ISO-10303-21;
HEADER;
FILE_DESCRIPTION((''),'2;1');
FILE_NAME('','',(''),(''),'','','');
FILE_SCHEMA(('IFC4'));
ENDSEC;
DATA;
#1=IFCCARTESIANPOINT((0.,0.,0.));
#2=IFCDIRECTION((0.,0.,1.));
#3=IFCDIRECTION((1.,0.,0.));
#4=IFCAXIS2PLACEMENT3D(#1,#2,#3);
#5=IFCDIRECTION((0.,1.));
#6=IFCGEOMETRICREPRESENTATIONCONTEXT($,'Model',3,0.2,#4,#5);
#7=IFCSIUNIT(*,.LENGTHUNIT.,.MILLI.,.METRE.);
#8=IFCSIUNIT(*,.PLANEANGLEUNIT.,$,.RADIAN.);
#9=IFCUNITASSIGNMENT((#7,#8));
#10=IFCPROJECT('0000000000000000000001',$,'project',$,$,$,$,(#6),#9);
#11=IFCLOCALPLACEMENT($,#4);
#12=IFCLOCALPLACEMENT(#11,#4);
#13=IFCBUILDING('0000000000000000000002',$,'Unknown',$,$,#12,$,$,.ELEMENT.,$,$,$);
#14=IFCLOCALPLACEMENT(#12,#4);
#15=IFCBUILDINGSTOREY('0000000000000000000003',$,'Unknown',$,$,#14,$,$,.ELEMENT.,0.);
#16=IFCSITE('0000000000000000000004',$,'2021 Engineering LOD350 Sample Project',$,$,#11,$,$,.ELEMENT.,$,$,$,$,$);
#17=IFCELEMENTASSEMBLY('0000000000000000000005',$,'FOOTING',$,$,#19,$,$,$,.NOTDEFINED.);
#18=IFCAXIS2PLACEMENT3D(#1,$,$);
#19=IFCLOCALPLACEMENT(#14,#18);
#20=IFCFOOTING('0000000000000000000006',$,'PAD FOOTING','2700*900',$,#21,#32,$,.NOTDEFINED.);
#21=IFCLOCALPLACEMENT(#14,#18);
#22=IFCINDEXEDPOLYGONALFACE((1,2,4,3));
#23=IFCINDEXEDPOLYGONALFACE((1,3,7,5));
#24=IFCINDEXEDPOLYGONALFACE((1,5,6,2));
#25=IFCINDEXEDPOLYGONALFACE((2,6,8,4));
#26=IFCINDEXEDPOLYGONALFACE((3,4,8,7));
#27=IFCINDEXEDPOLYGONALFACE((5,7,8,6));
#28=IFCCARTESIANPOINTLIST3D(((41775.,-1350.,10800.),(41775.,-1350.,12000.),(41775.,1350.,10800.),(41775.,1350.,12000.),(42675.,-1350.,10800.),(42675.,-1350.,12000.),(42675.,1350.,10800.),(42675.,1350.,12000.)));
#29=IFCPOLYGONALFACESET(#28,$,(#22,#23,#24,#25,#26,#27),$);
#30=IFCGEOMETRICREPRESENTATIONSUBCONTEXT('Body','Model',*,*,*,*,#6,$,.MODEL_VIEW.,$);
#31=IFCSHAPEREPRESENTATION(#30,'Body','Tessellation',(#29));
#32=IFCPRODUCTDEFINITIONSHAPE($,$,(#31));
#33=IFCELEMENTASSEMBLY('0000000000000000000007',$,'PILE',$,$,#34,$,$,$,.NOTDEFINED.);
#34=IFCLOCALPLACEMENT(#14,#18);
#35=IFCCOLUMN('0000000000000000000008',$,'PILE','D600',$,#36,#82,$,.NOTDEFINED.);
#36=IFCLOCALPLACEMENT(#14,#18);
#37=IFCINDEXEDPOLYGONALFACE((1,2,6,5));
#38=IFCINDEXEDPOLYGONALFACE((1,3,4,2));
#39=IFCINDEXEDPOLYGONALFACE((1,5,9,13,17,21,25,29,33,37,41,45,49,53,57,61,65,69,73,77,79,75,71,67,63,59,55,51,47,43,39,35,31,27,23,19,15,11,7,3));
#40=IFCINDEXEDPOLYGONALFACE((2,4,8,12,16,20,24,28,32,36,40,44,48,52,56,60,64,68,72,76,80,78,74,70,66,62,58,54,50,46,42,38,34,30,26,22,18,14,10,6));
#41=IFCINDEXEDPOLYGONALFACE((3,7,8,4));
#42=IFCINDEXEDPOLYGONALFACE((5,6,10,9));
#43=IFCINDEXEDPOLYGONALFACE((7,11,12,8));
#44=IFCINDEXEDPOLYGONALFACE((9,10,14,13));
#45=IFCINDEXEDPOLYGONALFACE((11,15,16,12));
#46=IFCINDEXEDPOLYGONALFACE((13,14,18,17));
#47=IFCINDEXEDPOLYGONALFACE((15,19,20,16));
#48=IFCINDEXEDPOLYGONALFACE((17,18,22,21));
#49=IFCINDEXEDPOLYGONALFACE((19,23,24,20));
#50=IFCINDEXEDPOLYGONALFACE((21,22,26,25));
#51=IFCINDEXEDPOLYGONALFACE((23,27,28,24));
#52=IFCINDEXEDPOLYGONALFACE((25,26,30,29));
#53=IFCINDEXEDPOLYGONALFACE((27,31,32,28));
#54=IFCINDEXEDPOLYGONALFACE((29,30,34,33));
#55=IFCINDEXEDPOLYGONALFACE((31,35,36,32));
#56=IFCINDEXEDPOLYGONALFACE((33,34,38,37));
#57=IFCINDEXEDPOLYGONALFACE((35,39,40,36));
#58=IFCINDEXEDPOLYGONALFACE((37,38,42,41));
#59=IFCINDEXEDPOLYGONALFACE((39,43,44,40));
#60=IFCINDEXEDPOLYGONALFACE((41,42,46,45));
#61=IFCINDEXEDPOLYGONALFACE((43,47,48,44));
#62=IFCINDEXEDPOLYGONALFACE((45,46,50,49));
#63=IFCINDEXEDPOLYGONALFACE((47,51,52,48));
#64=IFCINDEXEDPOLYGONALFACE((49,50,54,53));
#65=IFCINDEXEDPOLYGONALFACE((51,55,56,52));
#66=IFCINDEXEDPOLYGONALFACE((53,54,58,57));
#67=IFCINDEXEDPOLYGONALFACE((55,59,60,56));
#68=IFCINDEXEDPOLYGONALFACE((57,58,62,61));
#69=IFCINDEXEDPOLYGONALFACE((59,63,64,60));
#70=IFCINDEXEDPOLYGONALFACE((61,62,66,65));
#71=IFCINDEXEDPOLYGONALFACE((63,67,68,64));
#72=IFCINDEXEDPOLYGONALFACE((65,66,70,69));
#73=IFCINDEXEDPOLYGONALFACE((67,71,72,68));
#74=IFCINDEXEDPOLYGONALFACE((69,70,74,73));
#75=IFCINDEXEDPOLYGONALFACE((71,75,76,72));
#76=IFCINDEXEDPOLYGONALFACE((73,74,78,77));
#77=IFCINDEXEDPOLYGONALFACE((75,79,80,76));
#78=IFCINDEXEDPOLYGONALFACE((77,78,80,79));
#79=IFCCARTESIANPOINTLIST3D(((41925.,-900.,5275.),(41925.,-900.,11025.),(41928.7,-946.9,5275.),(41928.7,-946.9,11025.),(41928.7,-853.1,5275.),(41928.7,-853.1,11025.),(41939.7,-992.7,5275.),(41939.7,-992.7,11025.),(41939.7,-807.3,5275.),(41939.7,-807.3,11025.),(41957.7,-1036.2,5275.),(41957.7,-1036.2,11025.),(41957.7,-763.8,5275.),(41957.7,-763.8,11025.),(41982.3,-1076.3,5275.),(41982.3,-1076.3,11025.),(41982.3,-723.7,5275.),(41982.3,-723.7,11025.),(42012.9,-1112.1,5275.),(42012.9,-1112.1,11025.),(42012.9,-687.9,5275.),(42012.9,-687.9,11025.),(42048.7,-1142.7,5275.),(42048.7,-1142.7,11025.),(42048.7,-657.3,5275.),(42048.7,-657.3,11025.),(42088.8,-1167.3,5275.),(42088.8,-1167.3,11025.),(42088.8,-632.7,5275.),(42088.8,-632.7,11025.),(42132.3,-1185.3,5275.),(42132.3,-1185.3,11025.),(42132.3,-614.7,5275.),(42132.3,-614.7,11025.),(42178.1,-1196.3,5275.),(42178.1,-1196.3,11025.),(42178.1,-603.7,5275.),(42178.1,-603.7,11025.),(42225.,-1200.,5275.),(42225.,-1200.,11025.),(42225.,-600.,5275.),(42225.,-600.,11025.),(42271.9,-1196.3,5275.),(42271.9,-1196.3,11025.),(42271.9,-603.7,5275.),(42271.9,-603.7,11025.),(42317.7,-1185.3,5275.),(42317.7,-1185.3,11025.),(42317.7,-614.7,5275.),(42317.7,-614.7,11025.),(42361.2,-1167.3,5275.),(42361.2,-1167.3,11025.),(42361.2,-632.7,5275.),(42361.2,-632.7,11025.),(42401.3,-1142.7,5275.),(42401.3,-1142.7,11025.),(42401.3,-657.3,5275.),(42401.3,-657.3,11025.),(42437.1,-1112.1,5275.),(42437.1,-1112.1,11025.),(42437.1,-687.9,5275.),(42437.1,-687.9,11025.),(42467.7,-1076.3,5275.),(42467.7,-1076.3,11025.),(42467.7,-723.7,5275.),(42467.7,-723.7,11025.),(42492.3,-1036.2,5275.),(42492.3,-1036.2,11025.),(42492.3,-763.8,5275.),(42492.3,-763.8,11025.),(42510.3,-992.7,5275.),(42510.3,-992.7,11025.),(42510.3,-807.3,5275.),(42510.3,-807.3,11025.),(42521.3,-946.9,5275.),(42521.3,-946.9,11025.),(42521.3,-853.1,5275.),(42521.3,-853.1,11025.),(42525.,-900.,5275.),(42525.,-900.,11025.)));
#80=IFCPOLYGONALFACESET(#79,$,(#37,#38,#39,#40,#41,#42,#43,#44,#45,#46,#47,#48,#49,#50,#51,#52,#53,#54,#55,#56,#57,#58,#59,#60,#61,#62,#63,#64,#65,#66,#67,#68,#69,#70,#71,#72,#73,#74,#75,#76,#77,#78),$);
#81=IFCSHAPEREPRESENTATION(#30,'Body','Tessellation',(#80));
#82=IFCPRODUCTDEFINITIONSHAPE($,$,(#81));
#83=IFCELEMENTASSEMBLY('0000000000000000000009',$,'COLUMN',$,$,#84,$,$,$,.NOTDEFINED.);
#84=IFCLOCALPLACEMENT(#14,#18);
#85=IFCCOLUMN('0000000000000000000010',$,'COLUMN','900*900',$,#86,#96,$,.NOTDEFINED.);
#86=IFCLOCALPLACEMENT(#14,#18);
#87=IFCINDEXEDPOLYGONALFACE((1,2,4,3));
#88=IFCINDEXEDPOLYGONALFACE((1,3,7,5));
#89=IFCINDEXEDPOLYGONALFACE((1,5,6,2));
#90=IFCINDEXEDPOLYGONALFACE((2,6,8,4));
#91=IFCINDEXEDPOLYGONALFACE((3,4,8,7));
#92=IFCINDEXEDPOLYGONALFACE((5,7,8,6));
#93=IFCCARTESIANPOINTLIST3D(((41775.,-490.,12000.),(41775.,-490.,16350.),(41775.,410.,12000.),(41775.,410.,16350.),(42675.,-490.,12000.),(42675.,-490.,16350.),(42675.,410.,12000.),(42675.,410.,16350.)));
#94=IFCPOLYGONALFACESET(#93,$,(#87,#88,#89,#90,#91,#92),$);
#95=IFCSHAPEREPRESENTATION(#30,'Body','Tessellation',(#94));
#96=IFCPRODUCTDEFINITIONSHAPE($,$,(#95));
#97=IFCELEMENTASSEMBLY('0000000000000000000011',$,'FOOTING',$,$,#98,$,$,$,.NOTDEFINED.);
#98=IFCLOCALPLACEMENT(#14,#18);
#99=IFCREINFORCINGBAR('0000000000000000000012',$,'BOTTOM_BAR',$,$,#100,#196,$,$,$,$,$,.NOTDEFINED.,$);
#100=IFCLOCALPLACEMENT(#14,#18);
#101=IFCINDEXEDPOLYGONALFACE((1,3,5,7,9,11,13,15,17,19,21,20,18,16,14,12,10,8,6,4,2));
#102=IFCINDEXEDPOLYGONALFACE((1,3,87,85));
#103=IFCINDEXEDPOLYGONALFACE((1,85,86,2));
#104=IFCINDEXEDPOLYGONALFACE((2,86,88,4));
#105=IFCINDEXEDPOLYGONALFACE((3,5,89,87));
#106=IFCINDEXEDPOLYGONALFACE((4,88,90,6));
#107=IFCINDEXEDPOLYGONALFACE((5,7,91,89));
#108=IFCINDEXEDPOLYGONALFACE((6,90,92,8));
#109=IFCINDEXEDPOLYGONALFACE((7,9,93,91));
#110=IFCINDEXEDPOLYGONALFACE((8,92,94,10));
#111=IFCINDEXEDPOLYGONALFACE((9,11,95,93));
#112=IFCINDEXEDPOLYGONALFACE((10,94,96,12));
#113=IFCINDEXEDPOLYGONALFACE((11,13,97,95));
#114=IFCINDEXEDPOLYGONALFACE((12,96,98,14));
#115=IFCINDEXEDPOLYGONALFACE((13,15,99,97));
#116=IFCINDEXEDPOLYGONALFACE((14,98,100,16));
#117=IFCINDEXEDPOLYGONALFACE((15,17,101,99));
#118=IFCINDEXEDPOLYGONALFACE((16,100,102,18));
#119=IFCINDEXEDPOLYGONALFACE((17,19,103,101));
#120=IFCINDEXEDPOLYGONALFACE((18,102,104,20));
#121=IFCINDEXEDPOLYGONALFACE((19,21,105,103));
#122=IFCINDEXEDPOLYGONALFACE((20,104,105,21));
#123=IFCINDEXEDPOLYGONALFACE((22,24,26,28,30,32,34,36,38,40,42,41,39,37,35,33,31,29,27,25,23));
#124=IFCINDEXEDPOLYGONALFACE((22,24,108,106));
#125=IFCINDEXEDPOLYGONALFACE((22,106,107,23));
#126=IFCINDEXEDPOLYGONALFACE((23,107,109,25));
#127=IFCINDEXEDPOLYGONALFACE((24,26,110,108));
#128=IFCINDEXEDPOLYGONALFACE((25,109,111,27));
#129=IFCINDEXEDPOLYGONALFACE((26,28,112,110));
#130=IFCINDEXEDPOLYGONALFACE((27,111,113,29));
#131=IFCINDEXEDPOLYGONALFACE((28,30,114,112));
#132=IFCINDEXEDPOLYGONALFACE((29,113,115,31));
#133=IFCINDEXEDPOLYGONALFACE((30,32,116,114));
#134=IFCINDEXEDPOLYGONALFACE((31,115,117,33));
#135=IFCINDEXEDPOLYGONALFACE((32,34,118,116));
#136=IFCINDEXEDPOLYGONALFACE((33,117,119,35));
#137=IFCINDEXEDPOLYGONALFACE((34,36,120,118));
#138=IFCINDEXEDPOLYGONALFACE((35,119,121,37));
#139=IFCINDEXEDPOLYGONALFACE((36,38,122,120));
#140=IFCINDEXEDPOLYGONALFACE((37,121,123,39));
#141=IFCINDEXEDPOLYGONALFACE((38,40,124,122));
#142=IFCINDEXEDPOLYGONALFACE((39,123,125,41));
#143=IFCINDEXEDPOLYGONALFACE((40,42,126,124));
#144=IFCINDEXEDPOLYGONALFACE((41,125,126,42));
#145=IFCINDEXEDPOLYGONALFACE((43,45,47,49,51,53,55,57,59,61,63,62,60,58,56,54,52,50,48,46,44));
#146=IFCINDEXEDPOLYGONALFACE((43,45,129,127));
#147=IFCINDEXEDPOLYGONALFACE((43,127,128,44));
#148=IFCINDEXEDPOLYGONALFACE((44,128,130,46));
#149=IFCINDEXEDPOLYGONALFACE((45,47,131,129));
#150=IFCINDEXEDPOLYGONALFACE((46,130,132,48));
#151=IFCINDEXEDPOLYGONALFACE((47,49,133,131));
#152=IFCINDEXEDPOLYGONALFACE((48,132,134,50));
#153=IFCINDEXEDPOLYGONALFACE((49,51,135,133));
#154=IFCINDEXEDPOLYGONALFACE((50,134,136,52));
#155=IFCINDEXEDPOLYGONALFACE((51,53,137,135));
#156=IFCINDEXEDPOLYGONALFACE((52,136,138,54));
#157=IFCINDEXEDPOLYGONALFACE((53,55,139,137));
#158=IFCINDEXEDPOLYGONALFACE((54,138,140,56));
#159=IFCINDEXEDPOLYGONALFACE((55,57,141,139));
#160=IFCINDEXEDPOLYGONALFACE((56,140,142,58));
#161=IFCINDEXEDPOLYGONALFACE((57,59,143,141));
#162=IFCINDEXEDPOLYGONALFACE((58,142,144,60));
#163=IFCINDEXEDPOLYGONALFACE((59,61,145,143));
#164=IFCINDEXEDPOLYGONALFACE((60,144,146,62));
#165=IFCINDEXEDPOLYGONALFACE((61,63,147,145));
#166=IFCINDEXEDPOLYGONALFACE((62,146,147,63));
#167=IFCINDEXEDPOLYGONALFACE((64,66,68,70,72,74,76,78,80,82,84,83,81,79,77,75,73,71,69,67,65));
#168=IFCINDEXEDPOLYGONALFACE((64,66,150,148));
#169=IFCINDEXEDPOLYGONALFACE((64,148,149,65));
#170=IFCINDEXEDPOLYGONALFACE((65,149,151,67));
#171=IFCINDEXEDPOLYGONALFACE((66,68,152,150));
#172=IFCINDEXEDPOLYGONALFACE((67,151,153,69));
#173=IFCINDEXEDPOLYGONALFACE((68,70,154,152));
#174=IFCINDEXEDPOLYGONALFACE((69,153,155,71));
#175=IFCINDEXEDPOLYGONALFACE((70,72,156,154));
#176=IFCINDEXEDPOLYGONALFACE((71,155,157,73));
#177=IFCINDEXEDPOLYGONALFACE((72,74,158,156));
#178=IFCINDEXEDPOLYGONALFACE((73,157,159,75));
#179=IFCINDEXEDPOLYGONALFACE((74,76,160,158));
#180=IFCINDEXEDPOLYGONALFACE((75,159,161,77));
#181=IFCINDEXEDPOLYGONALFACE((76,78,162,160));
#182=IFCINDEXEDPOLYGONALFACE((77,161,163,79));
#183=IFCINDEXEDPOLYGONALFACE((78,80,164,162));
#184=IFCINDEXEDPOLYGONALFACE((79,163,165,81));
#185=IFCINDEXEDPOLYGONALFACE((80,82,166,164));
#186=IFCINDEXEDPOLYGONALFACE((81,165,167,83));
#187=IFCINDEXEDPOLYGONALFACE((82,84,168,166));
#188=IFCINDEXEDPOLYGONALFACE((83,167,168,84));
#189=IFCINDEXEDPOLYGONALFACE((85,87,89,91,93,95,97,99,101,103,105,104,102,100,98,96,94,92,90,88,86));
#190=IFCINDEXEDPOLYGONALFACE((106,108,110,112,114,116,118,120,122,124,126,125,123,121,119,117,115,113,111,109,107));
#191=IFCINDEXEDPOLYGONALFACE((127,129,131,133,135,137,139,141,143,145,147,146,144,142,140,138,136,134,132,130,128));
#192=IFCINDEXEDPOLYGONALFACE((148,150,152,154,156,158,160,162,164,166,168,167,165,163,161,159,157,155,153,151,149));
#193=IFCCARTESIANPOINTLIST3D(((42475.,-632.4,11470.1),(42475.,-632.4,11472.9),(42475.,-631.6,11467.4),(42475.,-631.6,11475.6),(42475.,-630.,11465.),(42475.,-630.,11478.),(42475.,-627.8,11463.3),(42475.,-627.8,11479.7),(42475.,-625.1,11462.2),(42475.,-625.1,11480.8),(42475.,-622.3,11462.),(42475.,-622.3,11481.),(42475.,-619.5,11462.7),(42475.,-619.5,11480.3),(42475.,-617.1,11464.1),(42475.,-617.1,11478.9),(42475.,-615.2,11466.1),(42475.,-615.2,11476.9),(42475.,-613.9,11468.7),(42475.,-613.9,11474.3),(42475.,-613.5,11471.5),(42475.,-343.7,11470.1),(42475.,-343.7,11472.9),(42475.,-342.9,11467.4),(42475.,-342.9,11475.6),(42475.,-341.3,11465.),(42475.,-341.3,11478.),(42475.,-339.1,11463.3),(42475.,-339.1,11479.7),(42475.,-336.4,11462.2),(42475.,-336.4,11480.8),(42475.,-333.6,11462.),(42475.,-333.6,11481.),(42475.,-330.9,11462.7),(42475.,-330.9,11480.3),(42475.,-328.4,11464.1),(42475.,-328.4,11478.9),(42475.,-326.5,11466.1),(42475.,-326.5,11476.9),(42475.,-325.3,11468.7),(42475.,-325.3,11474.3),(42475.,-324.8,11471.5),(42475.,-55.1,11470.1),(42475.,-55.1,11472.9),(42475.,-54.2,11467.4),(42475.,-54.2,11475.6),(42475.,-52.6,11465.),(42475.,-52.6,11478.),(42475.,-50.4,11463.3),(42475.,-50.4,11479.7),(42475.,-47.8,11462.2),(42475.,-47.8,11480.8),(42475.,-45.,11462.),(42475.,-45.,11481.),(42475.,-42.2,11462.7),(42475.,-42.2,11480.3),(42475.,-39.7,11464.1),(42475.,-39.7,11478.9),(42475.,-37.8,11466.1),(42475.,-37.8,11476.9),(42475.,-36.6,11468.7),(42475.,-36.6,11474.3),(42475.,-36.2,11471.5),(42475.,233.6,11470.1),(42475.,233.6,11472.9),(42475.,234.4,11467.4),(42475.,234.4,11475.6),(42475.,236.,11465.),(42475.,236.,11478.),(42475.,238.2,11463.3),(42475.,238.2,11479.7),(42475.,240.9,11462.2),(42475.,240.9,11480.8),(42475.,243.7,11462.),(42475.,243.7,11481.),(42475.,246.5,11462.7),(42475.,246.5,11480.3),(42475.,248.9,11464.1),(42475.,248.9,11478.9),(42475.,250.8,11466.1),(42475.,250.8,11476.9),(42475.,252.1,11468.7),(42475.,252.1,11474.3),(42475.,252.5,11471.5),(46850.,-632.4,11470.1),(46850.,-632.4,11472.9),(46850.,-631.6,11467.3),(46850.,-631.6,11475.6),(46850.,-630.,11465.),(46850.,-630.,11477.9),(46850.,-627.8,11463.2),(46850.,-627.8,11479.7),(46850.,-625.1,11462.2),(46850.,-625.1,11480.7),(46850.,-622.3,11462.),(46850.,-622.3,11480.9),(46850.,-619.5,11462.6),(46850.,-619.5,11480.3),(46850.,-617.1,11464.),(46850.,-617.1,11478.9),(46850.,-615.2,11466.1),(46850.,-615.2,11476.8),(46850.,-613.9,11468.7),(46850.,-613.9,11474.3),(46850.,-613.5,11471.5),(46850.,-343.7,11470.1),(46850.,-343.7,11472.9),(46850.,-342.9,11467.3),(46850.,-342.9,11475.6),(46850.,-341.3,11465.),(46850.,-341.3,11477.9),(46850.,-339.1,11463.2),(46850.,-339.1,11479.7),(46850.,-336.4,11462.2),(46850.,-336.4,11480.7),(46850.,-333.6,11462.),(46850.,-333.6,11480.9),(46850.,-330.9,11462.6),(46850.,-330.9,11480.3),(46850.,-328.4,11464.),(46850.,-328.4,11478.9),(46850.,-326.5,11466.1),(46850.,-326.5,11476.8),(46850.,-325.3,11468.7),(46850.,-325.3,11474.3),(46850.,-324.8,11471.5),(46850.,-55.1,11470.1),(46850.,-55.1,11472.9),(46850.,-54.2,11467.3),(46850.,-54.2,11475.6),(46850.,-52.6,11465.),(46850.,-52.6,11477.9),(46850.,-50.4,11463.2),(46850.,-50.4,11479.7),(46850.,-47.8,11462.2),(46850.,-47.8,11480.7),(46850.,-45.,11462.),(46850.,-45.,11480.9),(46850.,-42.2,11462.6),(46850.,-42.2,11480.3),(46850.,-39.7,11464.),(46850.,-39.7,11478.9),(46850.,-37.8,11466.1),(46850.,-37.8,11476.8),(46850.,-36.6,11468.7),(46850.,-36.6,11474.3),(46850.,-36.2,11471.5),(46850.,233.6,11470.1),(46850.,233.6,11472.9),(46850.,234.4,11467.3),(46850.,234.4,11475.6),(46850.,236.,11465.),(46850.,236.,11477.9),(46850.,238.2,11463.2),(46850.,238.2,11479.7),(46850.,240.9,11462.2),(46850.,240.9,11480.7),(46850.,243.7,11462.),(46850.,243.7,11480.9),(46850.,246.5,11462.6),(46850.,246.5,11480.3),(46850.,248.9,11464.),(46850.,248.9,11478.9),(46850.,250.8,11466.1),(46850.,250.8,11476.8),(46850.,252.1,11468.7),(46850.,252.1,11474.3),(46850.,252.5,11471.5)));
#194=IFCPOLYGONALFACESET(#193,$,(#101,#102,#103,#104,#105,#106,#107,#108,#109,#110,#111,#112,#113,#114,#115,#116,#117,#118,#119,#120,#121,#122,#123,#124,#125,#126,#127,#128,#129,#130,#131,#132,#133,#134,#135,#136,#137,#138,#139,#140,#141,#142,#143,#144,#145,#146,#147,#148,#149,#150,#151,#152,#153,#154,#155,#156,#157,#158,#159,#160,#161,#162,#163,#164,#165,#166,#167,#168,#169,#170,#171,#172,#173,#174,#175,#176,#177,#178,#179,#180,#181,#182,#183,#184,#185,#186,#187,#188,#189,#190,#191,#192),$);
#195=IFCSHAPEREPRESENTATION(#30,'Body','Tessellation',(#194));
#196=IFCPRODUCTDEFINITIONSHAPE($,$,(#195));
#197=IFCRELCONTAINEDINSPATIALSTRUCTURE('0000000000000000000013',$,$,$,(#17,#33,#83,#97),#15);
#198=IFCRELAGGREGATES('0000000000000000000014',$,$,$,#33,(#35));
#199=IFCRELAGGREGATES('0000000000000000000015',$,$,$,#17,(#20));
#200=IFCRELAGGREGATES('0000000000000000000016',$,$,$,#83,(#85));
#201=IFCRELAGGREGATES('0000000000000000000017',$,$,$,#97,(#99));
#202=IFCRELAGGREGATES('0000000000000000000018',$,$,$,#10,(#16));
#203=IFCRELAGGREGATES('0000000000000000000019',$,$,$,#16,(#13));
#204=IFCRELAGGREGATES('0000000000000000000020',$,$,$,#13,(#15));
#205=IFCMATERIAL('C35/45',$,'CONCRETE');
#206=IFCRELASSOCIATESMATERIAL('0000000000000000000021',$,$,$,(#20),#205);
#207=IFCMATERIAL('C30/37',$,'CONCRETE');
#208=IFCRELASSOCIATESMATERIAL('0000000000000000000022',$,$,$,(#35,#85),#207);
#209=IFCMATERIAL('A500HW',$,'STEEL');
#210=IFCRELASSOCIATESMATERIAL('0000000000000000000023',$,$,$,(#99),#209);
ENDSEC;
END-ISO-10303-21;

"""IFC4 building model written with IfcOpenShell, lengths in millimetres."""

from ifc_helpers import new_model, entity, si_unit, direction, frame, origin_with_axes, place, context, subcontext, project, spatial, line, indexed_curve, outline, extrude, source, transform, mapped, material, element, aggregate, save


model = new_model("IFC4")

# Units and contexts
model_context = context("Model", 3, precision=0.2, world=origin_with_axes(), true_north=direction((0.0, 1.0)))
body_context = subcontext(model_context, "Body", "Model", "MODEL_VIEW")
ifc_project = project(units=[si_unit("LENGTHUNIT", "METRE", prefix="MILLI"), si_unit("PLANEANGLEUNIT", "RADIAN")], contexts=[model_context])

# Site, building, storey
site_placement = place(None, origin_with_axes())
site = spatial("IfcSite", under=ifc_project, at=site_placement, Name="2021 Engineering LOD350 Sample Project", CompositionType="ELEMENT")
building_placement = place(site_placement, origin_with_axes())
building = spatial("IfcBuilding", under=site, at=building_placement, Name="Unknown", CompositionType="ELEMENT")
storey_placement = place(building_placement, origin_with_axes())
storey = spatial("IfcBuildingStorey", under=building, at=storey_placement, Name="Unknown", CompositionType="ELEMENT", Elevation=0.0)

# Element assembly, footing
assembly_1_placement = place(storey_placement, frame((42225.0, 0.0, 10800.0), z_axis=(-1.0, 0.0, 0.0), x_axis=(0.0, 0.0, 1.0)))
assembly_1 = element("IfcElementAssembly", 1, at=assembly_1_placement, inside=storey, Name="FOOTING", PredefinedType="NOTDEFINED")
ifc_material_1 = material(Name="C35/45", Category="CONCRETE")
footing_placement = place(assembly_1_placement, origin_with_axes())
footing = element("IfcFooting", 2, at=footing_placement, material=ifc_material_1, Name="PAD FOOTING", Description="2700*900", PredefinedType="NOTDEFINED", context=body_context, shape_type="SolidModel", body=[
    extrude(outline(indexed_curve([(-450.0, -1350.0), (450.0, -1350.0), (450.0, 1350.0), (-450.0, 1350.0)], segments=[line(1, 2, 3, 4, 1)])), frame((0.0, 0.0, 0.0), z_axis=(-1.0, 0.0, 0.0), x_axis=(0.0, 0.0, 1.0)), (0.0, 0.0, -1.0), 1200.0),
])

# Element assemblies, columns
assembly_2_placement = place(storey_placement, frame((42225.0, -900.0, 5275.0), z_axis=(-1.0, 0.0, 0.0), x_axis=(0.0, 0.0, 1.0)))
assembly_2 = element("IfcElementAssembly", 3, at=assembly_2_placement, inside=storey, Name="PILE", PredefinedType="NOTDEFINED")
ifc_material_2 = material(Name="C30/37", Category="CONCRETE")
column_1_placement = place(assembly_2_placement, origin_with_axes())
column_1 = element("IfcColumn", 4, at=column_1_placement, material=ifc_material_2, Name="PILE", Description="D600", PredefinedType="NOTDEFINED", context=body_context, shape_type="SolidModel", body=[
    extrude(outline(indexed_curve([(300.0, 0.0), (296.3, 46.9), (285.3, 92.7), (267.3, 136.2), (242.7, 176.3), (212.1, 212.1), (176.3, 242.7), (136.2, 267.3), (92.7, 285.3), (46.9, 296.3), (0.0, 300.0), (-46.9, 296.3), (-92.7, 285.3), (-136.2, 267.3), (-176.3, 242.7), (-212.1, 212.1), (-242.7, 176.3), (-267.3, 136.2), (-285.3, 92.7), (-296.3, 46.9), (-300.0, 0.0), (-296.3, -46.9), (-285.3, -92.7), (-267.3, -136.2), (-242.7, -176.3), (-212.1, -212.1), (-176.3, -242.7), (-136.2, -267.3), (-92.7, -285.3), (-46.9, -296.3), (0.0, -300.0), (46.9, -296.3), (92.7, -285.3), (136.2, -267.3), (176.3, -242.7), (212.1, -212.1), (242.7, -176.3), (267.3, -136.2), (285.3, -92.7), (296.3, -46.9)], segments=[line(1, 2, 3, 4, 5, 6, 7, 8, 9, 10, 11, 12, 13, 14, 15, 16, 17, 18, 19, 20, 21, 22, 23, 24, 25, 26, 27, 28, 29, 30, 31, 32, 33, 34, 35, 36, 37, 38, 39, 40, 1)])), frame((0.0, 0.0, 0.0), z_axis=(-1.0, 0.0, 0.0), x_axis=(0.0, 0.0, 1.0)), (0.0, 0.0, -1.0), 5750.0),
])
aggregate(assembly_2, [column_1])
assembly_3_placement = place(storey_placement, frame((42225.0, -40.0, 12000.0), z_axis=(-1.0, 0.0, 0.0), x_axis=(0.0, 0.0, 1.0)))
assembly_3 = element("IfcElementAssembly", 5, at=assembly_3_placement, inside=storey, Name="COLUMN", PredefinedType="NOTDEFINED")
column_2_placement = place(assembly_3_placement, origin_with_axes())
column_2 = element("IfcColumn", 6, at=column_2_placement, material=ifc_material_2, Name="COLUMN", Description="900*900", PredefinedType="NOTDEFINED", context=body_context, shape_type="SolidModel", body=[
    extrude(outline(indexed_curve([(-450.0, -450.0), (450.0, -450.0), (450.0, 450.0), (-450.0, 450.0)], segments=[line(1, 2, 3, 4, 1)])), frame((0.0, 0.0, 0.0), z_axis=(-1.0, 0.0, 0.0), x_axis=(0.0, 0.0, 1.0)), (0.0, 0.0, -1.0), 4350.0),
])

# Shared definitions
ifc_material_3 = material(Name="A500HW", Category="STEEL")
aggregate(assembly_1, [footing])

# Element assembly, reinforcing bar
assembly_4_placement = place(storey_placement, frame((42225.0, -190.0, 11700.0), z_axis=(0.0, -1.0, 0.0), x_axis=(1.0, 0.0, -0.000006)))
assembly_4 = element("IfcElementAssembly", 7, at=assembly_4_placement, inside=storey, Name="FOOTING", PredefinedType="NOTDEFINED")
shared_shape_1 = source(origin_with_axes(), body_context, "Body", "AdvancedSweptSolid", [
    entity("IfcSweptDiskSolid", entity("IfcIndexedPolyCurve", entity("IfcCartesianPointList3D", [[0.0, 0.0, 0.0], [4375.0, 0.0, 0.0]]), [entity("IfcLineIndex", [1, 2])]), 9.5),
])
reinforcing_bar_1_placement = place(assembly_4_placement, frame((250.0, -228.5, -433.0), z_axis=(0.0, 0.0, -1.0), x_axis=(1.0, 0.0, 0.0)))
reinforcing_bar_1 = element("IfcReinforcingBar", 8, at=reinforcing_bar_1_placement, material=ifc_material_3, Name="BOTTOM_BAR", PredefinedType="NOTDEFINED", context=body_context, shape_type="MappedRepresentation", body=[
    mapped(shared_shape_1, transform((0.0, 0.0, 0.0))),
    mapped(shared_shape_1, transform((0.0, 0.0, -288.7))),
    mapped(shared_shape_1, transform((0.0, 0.0, -577.3))),
    mapped(shared_shape_1, transform((0.0, 0.0, -866.0))),
])

aggregate(assembly_3, [column_2])

aggregate(assembly_4, [reinforcing_bar_1])

save(model, "model.ifc")
